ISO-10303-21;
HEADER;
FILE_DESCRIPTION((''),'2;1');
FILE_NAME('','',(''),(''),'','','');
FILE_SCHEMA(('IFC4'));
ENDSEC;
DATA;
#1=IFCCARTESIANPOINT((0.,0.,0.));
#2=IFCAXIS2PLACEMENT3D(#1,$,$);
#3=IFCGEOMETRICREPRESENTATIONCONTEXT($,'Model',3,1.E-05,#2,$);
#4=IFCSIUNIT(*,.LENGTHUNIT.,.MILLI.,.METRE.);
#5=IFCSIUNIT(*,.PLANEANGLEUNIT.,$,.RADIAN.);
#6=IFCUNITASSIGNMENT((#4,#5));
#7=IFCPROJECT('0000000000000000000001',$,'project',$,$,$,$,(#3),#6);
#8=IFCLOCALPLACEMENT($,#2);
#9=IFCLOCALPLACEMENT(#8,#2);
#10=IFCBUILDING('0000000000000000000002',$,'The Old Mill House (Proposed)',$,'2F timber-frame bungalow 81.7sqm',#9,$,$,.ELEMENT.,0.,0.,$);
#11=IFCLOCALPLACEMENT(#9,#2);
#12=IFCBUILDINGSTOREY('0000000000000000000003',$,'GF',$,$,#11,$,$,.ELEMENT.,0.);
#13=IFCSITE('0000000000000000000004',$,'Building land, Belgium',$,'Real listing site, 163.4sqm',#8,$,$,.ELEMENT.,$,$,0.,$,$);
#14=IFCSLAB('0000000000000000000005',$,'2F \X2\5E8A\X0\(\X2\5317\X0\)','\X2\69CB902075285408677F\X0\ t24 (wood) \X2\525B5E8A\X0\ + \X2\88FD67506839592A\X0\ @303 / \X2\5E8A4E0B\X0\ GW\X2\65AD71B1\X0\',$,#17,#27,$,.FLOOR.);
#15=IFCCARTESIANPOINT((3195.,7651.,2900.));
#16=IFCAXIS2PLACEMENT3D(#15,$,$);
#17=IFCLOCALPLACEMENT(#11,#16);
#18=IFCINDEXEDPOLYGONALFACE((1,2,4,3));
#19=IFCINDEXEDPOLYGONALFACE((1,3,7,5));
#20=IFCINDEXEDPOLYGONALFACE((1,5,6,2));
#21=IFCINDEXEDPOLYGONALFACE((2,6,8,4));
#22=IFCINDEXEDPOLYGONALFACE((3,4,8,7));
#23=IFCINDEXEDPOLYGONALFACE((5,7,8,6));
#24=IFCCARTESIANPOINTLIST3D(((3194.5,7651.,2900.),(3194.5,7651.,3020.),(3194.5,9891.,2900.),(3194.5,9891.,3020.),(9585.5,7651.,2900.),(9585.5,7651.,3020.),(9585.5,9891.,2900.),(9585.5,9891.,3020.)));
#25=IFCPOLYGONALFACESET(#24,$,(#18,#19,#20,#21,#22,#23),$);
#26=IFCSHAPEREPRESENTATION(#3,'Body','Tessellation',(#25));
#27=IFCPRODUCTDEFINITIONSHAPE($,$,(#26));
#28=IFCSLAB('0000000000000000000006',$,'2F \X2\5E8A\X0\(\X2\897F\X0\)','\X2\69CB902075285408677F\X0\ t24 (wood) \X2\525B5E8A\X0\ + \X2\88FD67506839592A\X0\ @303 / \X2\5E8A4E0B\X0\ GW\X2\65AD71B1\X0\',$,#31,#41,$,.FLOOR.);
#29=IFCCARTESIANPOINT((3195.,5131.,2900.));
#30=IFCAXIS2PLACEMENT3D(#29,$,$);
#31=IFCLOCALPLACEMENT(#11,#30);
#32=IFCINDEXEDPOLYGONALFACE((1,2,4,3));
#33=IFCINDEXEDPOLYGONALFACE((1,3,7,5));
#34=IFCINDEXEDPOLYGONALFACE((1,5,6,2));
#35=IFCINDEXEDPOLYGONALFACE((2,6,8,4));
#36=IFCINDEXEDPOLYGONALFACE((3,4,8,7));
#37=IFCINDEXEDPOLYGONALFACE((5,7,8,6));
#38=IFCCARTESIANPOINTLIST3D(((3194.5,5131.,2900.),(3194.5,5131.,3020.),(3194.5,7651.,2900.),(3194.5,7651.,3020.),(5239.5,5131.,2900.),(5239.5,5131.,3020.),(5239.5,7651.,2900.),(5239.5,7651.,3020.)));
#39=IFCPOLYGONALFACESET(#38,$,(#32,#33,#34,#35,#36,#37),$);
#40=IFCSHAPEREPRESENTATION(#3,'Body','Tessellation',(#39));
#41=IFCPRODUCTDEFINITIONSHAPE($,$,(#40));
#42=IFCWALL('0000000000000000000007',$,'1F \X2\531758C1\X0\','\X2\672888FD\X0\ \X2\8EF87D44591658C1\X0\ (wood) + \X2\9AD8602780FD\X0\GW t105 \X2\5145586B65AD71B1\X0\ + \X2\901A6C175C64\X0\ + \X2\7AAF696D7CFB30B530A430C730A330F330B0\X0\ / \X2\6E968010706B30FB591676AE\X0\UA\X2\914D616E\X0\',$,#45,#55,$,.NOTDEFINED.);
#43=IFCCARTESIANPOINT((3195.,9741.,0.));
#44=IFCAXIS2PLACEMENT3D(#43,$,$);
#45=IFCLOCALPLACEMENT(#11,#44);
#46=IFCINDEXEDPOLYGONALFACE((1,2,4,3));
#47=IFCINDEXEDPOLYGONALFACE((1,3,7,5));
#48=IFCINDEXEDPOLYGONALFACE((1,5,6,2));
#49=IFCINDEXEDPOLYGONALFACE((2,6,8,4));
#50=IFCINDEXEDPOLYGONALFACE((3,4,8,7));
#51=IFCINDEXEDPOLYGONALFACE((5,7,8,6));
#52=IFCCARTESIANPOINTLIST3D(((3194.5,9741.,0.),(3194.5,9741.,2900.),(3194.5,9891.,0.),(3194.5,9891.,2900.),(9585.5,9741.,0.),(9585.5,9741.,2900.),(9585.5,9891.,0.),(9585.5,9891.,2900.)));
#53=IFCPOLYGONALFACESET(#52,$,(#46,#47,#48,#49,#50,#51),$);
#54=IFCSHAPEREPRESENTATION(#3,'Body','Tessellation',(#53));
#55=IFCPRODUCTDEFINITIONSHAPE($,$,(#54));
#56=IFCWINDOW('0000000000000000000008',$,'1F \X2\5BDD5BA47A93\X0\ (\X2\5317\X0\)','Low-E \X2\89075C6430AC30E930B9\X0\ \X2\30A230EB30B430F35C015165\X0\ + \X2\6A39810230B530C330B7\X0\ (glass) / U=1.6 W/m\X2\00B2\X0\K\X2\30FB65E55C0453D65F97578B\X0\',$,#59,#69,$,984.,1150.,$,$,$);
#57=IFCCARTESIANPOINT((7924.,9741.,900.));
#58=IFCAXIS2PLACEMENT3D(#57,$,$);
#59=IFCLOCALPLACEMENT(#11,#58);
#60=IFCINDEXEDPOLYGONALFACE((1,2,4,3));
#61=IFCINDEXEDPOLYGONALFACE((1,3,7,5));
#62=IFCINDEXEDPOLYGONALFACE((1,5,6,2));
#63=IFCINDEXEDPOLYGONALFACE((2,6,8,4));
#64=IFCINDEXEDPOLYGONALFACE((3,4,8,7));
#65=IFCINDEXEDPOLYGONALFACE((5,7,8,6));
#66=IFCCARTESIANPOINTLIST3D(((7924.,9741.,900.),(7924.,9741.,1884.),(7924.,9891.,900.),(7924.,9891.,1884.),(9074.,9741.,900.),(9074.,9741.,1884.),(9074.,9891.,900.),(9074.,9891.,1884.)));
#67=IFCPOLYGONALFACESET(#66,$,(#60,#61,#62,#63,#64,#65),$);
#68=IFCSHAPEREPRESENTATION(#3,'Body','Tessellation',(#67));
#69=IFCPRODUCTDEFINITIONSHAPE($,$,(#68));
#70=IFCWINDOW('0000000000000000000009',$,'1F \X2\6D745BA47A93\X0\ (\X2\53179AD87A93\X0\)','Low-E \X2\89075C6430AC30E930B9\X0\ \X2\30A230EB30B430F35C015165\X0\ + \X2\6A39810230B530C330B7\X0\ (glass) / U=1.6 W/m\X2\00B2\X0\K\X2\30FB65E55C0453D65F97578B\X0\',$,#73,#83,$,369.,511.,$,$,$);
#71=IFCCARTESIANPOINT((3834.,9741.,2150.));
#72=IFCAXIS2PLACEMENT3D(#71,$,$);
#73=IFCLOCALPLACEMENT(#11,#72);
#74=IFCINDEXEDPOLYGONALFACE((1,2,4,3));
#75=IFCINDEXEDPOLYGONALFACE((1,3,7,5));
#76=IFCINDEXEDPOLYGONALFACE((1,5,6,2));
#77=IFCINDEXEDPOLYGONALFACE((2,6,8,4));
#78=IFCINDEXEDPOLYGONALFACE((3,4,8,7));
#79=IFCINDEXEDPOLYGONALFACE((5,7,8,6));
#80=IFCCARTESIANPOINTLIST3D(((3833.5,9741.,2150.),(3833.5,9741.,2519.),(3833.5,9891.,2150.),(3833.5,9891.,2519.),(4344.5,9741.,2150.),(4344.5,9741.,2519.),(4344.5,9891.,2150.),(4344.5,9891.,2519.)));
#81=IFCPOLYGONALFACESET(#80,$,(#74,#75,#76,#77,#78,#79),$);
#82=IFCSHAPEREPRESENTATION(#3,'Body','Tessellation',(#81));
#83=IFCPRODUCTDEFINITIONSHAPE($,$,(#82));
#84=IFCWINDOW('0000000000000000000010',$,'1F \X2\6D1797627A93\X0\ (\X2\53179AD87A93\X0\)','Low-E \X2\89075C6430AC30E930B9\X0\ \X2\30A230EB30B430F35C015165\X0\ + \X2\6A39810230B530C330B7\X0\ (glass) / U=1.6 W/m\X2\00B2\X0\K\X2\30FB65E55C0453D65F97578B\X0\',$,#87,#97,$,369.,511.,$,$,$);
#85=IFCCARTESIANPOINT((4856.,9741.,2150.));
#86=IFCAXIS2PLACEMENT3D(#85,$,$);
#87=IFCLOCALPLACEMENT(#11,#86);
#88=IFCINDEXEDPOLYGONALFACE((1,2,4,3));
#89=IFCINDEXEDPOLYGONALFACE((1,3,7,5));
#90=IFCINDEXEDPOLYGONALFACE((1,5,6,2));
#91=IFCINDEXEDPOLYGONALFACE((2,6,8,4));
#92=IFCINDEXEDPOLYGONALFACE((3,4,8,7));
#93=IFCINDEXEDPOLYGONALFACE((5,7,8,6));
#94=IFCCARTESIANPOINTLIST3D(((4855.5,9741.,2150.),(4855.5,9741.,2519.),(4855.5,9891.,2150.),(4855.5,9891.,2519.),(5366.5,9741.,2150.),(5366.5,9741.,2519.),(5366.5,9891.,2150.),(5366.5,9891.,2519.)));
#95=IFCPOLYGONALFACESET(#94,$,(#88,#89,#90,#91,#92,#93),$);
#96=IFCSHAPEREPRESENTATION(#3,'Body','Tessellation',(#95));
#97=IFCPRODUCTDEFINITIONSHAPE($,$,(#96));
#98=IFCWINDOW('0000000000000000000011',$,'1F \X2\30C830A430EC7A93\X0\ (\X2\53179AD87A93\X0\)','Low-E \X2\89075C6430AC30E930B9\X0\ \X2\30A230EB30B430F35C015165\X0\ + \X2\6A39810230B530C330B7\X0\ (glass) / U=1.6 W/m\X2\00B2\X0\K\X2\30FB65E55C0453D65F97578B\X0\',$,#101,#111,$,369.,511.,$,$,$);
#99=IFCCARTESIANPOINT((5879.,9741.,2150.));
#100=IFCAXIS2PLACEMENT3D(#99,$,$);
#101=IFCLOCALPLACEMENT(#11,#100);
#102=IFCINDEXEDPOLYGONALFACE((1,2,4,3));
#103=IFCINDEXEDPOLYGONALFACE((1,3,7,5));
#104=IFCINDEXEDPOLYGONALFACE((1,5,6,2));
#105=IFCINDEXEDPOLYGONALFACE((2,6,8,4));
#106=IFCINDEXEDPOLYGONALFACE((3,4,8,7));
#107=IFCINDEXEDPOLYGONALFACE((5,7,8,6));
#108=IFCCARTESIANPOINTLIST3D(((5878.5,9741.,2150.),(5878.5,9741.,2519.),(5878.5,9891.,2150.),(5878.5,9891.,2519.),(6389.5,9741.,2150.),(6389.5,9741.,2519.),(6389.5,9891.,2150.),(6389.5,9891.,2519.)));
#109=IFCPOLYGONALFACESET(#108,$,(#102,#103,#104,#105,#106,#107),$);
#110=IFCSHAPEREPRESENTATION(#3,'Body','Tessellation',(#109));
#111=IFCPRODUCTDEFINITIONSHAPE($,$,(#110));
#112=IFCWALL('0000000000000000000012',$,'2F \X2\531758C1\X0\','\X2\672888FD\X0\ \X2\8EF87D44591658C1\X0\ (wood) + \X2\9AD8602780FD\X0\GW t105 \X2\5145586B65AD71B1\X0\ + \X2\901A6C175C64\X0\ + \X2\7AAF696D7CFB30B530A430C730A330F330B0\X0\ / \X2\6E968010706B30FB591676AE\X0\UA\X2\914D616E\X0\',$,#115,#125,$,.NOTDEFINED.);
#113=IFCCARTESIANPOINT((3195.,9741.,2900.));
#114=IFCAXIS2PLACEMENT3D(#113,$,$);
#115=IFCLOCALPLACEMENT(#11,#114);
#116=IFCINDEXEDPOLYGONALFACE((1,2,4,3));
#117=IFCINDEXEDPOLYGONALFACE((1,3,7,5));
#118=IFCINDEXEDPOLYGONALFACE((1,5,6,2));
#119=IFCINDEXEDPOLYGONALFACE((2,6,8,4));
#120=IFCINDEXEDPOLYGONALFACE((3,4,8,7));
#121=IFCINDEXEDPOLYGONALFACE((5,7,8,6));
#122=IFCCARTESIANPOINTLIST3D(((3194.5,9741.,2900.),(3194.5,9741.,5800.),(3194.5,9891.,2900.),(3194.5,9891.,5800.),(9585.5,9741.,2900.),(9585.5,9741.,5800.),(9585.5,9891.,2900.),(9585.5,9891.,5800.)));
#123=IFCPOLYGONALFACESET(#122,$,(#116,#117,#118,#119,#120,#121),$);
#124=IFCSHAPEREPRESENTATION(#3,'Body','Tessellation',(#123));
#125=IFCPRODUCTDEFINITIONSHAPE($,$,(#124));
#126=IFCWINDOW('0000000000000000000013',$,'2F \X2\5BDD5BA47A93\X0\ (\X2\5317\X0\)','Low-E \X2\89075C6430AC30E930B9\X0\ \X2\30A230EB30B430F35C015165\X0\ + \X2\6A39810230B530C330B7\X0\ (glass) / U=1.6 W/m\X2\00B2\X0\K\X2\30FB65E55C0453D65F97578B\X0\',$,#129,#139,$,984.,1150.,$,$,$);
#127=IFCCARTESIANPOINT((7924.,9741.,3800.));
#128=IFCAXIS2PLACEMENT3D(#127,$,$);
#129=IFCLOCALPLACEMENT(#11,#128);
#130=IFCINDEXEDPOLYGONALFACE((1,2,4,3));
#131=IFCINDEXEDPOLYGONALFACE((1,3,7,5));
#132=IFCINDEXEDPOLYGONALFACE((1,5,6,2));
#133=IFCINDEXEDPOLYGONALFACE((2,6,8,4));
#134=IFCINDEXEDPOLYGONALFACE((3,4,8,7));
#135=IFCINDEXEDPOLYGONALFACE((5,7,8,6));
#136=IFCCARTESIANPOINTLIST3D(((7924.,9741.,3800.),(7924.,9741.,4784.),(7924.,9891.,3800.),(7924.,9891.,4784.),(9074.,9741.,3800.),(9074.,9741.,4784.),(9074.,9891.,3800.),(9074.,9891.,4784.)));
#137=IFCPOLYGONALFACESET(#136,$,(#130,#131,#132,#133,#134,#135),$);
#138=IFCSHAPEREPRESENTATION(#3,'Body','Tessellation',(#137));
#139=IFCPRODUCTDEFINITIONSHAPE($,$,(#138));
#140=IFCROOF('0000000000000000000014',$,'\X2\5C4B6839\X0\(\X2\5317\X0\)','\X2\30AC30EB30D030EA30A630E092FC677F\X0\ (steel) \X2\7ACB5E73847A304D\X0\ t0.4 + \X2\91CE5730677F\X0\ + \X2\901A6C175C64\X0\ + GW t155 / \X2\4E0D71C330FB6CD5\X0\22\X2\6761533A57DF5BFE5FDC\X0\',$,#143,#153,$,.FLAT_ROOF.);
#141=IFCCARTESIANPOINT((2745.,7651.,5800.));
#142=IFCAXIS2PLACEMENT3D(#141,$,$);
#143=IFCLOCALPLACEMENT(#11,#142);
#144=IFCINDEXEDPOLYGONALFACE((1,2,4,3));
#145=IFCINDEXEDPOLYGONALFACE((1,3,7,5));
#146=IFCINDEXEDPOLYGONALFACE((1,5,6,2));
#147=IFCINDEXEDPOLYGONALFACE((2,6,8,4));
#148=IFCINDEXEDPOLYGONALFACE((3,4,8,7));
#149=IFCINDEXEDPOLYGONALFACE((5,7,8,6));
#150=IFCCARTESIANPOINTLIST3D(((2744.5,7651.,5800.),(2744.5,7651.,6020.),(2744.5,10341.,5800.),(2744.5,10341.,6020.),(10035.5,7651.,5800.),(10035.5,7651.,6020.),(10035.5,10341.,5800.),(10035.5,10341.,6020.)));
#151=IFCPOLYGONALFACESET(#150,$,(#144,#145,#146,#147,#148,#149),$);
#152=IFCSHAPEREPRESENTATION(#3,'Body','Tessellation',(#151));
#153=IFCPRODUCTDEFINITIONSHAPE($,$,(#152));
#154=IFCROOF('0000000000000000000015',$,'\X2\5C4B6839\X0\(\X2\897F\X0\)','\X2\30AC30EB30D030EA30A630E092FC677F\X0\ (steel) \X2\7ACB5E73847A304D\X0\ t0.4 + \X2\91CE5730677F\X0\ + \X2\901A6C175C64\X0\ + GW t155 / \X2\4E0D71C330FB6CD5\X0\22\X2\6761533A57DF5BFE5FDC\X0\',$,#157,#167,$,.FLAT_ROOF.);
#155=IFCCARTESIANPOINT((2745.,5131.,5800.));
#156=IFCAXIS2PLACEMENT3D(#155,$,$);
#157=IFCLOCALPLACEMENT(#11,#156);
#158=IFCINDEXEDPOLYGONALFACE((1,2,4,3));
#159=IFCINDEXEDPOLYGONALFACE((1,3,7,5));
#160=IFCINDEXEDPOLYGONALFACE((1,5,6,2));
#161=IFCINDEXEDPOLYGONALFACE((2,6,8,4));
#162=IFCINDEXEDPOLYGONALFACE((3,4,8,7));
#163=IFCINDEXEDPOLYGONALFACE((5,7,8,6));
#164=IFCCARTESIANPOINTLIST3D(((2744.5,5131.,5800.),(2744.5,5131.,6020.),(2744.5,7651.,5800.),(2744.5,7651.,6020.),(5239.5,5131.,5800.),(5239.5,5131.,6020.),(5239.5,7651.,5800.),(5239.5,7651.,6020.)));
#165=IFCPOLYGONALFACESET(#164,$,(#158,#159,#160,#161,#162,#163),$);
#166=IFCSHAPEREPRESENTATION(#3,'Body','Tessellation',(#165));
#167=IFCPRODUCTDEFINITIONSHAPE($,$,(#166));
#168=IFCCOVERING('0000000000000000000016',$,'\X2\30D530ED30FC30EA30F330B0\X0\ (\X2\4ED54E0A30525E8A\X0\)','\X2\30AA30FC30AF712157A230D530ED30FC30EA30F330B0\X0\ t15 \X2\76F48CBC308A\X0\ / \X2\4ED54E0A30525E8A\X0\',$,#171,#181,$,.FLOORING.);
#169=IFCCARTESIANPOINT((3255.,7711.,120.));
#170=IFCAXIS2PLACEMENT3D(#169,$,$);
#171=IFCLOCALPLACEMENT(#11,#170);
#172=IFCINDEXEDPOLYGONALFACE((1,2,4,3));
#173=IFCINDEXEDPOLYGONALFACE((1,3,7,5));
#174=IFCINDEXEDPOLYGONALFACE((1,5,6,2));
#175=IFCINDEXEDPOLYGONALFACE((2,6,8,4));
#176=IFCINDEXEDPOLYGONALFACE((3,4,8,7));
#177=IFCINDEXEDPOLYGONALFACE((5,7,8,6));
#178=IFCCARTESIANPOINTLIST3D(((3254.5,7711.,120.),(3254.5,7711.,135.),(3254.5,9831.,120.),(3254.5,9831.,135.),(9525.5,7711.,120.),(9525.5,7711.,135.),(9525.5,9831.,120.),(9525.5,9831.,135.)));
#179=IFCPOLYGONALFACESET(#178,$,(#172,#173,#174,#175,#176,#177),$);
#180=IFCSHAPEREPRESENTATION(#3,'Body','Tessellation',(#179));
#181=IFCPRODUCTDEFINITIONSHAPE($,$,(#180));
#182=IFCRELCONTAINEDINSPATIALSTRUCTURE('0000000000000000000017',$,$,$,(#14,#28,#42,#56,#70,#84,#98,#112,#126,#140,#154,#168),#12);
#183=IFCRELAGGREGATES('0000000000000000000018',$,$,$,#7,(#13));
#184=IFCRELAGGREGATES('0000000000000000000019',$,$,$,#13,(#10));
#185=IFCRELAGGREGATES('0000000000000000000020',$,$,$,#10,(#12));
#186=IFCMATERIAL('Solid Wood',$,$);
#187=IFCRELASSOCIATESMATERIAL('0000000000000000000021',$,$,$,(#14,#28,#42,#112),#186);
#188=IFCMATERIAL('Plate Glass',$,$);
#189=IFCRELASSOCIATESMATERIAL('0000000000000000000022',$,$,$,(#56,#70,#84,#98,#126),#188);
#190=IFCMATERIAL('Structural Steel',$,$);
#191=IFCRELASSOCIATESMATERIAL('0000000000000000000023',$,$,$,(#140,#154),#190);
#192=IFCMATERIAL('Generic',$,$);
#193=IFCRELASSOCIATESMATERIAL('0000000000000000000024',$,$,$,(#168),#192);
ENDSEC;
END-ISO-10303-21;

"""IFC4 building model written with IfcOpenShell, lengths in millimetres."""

from ifc_helpers import new_model, si_unit, frame, frame_2d, origin, place, context, project, spatial, rectangle, extrude, material, element, fill, save


model = new_model("IFC4")

# Units and contexts
model_context = context("Model", 3, precision=1e-05, world=origin())
ifc_project = project(units=[si_unit("LENGTHUNIT", "METRE", prefix="MILLI"), si_unit("PLANEANGLEUNIT", "RADIAN")], contexts=[model_context])

# Site, building, storey
site_placement = place(None, origin())
site = spatial("IfcSite", under=ifc_project, at=site_placement, Name="Building land, Belgium", ObjectType="Real listing site, 163.4sqm", CompositionType="ELEMENT", RefElevation=0.0)
building_placement = place(site_placement, origin())
building = spatial("IfcBuilding", under=site, at=building_placement, Name="The Old Mill House (Proposed)", ObjectType="2F timber-frame bungalow 81.7sqm", CompositionType="ELEMENT", ElevationOfRefHeight=0.0, ElevationOfTerrain=0.0)
storey_placement = place(building_placement, origin())
storey = spatial("IfcBuildingStorey", under=building, at=storey_placement, Name="GF", CompositionType="ELEMENT", Elevation=0.0)

# Slabs
ifc_material_1 = material(Name="Solid Wood")
slab_1_placement = place(storey_placement, frame((3195.0, 7651.0, 2900.0)))
element("IfcSlab", 1, at=slab_1_placement, inside=storey, material=ifc_material_1, Name="2F 床(北)", Description="構造用合板 t24 (wood) 剛床 + 製材根太 @303 / 床下 GW断熱", PredefinedType="FLOOR", context=model_context, shape_type="SweptSolid", body=[
    extrude(rectangle(XDim=6391.0, YDim=2240.0, at=frame_2d((3195.0, 1120.0))), frame((3195.0, 7651.0, 2900.0)), (0.0, 0.0, 1.0), 120.0),
])
slab_2_placement = place(storey_placement, frame((3195.0, 5131.0, 2900.0)))
element("IfcSlab", 2, at=slab_2_placement, inside=storey, material=ifc_material_1, Name="2F 床(西)", Description="構造用合板 t24 (wood) 剛床 + 製材根太 @303 / 床下 GW断熱", PredefinedType="FLOOR", context=model_context, shape_type="SweptSolid", body=[
    extrude(rectangle(XDim=2045.0, YDim=2520.0, at=frame_2d((1022.0, 1260.0))), frame((3195.0, 5131.0, 2900.0)), (0.0, 0.0, 1.0), 120.0),
])

# Wall, openings, windows
wall_1_placement = place(storey_placement, frame((3195.0, 9741.0, 0.0)))
wall_1 = element("IfcWall", 3, at=wall_1_placement, inside=storey, material=ifc_material_1, Name="1F 北壁", Description="木製 軸組外壁 (wood) + 高性能GW t105 充填断熱 + 通気層 + 窯業系サイディング / 準耐火・外皮UA配慮", PredefinedType="NOTDEFINED", context=model_context, shape_type="SweptSolid", body=[
    extrude(rectangle(XDim=6391.0, YDim=150.0, at=frame_2d((3195.0, 75.0))), frame((3195.0, 9741.0, 0.0)), (0.0, 0.0, 1.0), 2900.0),
])
opening_1_placement = place(storey_placement, frame((7924.0, 9741.0, 900.0)))
opening_1 = element("IfcOpeningElement", 4, at=opening_1_placement, cuts=wall_1, PredefinedType="NOTDEFINED", context=model_context, shape_type="SweptSolid", body=[
    extrude(rectangle(XDim=1150.0, YDim=150.0, at=frame_2d((575.0, 75.0))), frame((7924.0, 9741.0, 900.0)), (0.0, 0.0, 1.0), 984.0),
])
opening_2_placement = place(storey_placement, frame((3834.0, 9741.0, 2150.0)))
opening_2 = element("IfcOpeningElement", 5, at=opening_2_placement, cuts=wall_1, PredefinedType="NOTDEFINED", context=model_context, shape_type="SweptSolid", body=[
    extrude(rectangle(XDim=511.0, YDim=150.0, at=frame_2d((255.0, 75.0))), frame((3834.0, 9741.0, 2150.0)), (0.0, 0.0, 1.0), 369.0),
])
opening_3_placement = place(storey_placement, frame((4856.0, 9741.0, 2150.0)))
opening_3 = element("IfcOpeningElement", 6, at=opening_3_placement, cuts=wall_1, PredefinedType="NOTDEFINED", context=model_context, shape_type="SweptSolid", body=[
    extrude(rectangle(XDim=511.0, YDim=150.0, at=frame_2d((255.0, 75.0))), frame((4856.0, 9741.0, 2150.0)), (0.0, 0.0, 1.0), 369.0),
])
opening_4_placement = place(storey_placement, frame((5879.0, 9741.0, 2150.0)))
opening_4 = element("IfcOpeningElement", 7, at=opening_4_placement, cuts=wall_1, PredefinedType="NOTDEFINED", context=model_context, shape_type="SweptSolid", body=[
    extrude(rectangle(XDim=511.0, YDim=150.0, at=frame_2d((255.0, 75.0))), frame((5879.0, 9741.0, 2150.0)), (0.0, 0.0, 1.0), 369.0),
])
ifc_material_2 = material(Name="Plate Glass")
window_1_placement = place(storey_placement, frame((7924.0, 9741.0, 900.0)))
window_1 = element("IfcWindow", 8, at=window_1_placement, inside=storey, material=ifc_material_2, Name="1F 寝室窓 (北)", Description="Low-E 複層ガラス アルゴン封入 + 樹脂サッシ (glass) / U=1.6 W/m²K・日射取得型", OverallHeight=984.0, OverallWidth=1150.0, context=model_context, shape_type="SweptSolid", body=[
    extrude(rectangle(XDim=1150.0, YDim=150.0, at=frame_2d((575.0, 75.0))), frame((7924.0, 9741.0, 900.0)), (0.0, 0.0, 1.0), 984.0),
])
fill(opening_1, window_1)
window_2_placement = place(storey_placement, frame((3834.0, 9741.0, 2150.0)))
window_2 = element("IfcWindow", 9, at=window_2_placement, inside=storey, material=ifc_material_2, Name="1F 浴室窓 (北高窓)", Description="Low-E 複層ガラス アルゴン封入 + 樹脂サッシ (glass) / U=1.6 W/m²K・日射取得型", OverallHeight=369.0, OverallWidth=511.0, context=model_context, shape_type="SweptSolid", body=[
    extrude(rectangle(XDim=511.0, YDim=150.0, at=frame_2d((255.0, 75.0))), frame((3834.0, 9741.0, 2150.0)), (0.0, 0.0, 1.0), 369.0),
])
fill(opening_2, window_2)
window_3_placement = place(storey_placement, frame((4856.0, 9741.0, 2150.0)))
window_3 = element("IfcWindow", 10, at=window_3_placement, inside=storey, material=ifc_material_2, Name="1F 洗面窓 (北高窓)", Description="Low-E 複層ガラス アルゴン封入 + 樹脂サッシ (glass) / U=1.6 W/m²K・日射取得型", OverallHeight=369.0, OverallWidth=511.0, context=model_context, shape_type="SweptSolid", body=[
    extrude(rectangle(XDim=511.0, YDim=150.0, at=frame_2d((255.0, 75.0))), frame((4856.0, 9741.0, 2150.0)), (0.0, 0.0, 1.0), 369.0),
])
fill(opening_3, window_3)
window_4_placement = place(storey_placement, frame((5879.0, 9741.0, 2150.0)))
window_4 = element("IfcWindow", 11, at=window_4_placement, inside=storey, material=ifc_material_2, Name="1F トイレ窓 (北高窓)", Description="Low-E 複層ガラス アルゴン封入 + 樹脂サッシ (glass) / U=1.6 W/m²K・日射取得型", OverallHeight=369.0, OverallWidth=511.0, context=model_context, shape_type="SweptSolid", body=[
    extrude(rectangle(XDim=511.0, YDim=150.0, at=frame_2d((255.0, 75.0))), frame((5879.0, 9741.0, 2150.0)), (0.0, 0.0, 1.0), 369.0),
])
fill(opening_4, window_4)

# Wall, opening, window
wall_2_placement = place(storey_placement, frame((3195.0, 9741.0, 2900.0)))
wall_2 = element("IfcWall", 12, at=wall_2_placement, inside=storey, material=ifc_material_1, Name="2F 北壁", Description="木製 軸組外壁 (wood) + 高性能GW t105 充填断熱 + 通気層 + 窯業系サイディング / 準耐火・外皮UA配慮", PredefinedType="NOTDEFINED", context=model_context, shape_type="SweptSolid", body=[
    extrude(rectangle(XDim=6391.0, YDim=150.0, at=frame_2d((3195.0, 75.0))), frame((3195.0, 9741.0, 2900.0)), (0.0, 0.0, 1.0), 2900.0),
])
opening_5_placement = place(storey_placement, frame((7924.0, 9741.0, 3800.0)))
opening_5 = element("IfcOpeningElement", 13, at=opening_5_placement, cuts=wall_2, PredefinedType="NOTDEFINED", context=model_context, shape_type="SweptSolid", body=[
    extrude(rectangle(XDim=1150.0, YDim=150.0, at=frame_2d((575.0, 75.0))), frame((7924.0, 9741.0, 3800.0)), (0.0, 0.0, 1.0), 984.0),
])
window_5_placement = place(storey_placement, frame((7924.0, 9741.0, 3800.0)))
window_5 = element("IfcWindow", 14, at=window_5_placement, inside=storey, material=ifc_material_2, Name="2F 寝室窓 (北)", Description="Low-E 複層ガラス アルゴン封入 + 樹脂サッシ (glass) / U=1.6 W/m²K・日射取得型", OverallHeight=984.0, OverallWidth=1150.0, context=model_context, shape_type="SweptSolid", body=[
    extrude(rectangle(XDim=1150.0, YDim=150.0, at=frame_2d((575.0, 75.0))), frame((7924.0, 9741.0, 3800.0)), (0.0, 0.0, 1.0), 984.0),
])
fill(opening_5, window_5)

# Roofs
ifc_material_3 = material(Name="Structural Steel")
for number, where, name in (
    (15, (2745.0, 7651.0, 5800.0), "屋根(北)"),
):
    element("IfcRoof", number, at=place(storey_placement, frame(where)), inside=storey, material=ifc_material_3, Name=name, Description="ガルバリウム鋼板 (steel) 立平葺き t0.4 + 野地板 + 通気層 + GW t155 / 不燃・法22条区域対応", PredefinedType="FLAT_ROOF", context=model_context, shape_type="SweptSolid", body=[
        extrude(rectangle(XDim=7291.0, YDim=2690.0, at=frame_2d((3645.0, 1345.0))), frame((2745.0, 7651.0, 5800.0)), (0.0, 0.0, 1.0), 220.0),
    ])
roof_placement = place(storey_placement, frame((2745.0, 5131.0, 5800.0)))
element("IfcRoof", 16, at=roof_placement, inside=storey, material=ifc_material_3, Name="屋根(西)", Description="ガルバリウム鋼板 (steel) 立平葺き t0.4 + 野地板 + 通気層 + GW t155 / 不燃・法22条区域対応", PredefinedType="FLAT_ROOF", context=model_context, shape_type="SweptSolid", body=[
    extrude(rectangle(XDim=2495.0, YDim=2520.0, at=frame_2d((1247.0, 1260.0))), frame((2745.0, 5131.0, 5800.0)), (0.0, 0.0, 1.0), 220.0),
])

# Covering
ifc_material_4 = material(Name="Generic")
covering_1_placement = place(storey_placement, frame((3255.0, 7711.0, 120.0)))
element("IfcCovering", 17, at=covering_1_placement, inside=storey, material=ifc_material_4, Name="フローリング (仕上げ床)", Description="オーク無垢フローリング t15 直貼り / 仕上げ床", PredefinedType="FLOORING", context=model_context, shape_type="SweptSolid", body=[
    extrude(rectangle(XDim=6271.0, YDim=2120.0, at=frame_2d((3135.0, 1060.0))), frame((3255.0, 7711.0, 120.0)), (0.0, 0.0, 1.0), 15.0),
])

save(model, "model.ifc")
